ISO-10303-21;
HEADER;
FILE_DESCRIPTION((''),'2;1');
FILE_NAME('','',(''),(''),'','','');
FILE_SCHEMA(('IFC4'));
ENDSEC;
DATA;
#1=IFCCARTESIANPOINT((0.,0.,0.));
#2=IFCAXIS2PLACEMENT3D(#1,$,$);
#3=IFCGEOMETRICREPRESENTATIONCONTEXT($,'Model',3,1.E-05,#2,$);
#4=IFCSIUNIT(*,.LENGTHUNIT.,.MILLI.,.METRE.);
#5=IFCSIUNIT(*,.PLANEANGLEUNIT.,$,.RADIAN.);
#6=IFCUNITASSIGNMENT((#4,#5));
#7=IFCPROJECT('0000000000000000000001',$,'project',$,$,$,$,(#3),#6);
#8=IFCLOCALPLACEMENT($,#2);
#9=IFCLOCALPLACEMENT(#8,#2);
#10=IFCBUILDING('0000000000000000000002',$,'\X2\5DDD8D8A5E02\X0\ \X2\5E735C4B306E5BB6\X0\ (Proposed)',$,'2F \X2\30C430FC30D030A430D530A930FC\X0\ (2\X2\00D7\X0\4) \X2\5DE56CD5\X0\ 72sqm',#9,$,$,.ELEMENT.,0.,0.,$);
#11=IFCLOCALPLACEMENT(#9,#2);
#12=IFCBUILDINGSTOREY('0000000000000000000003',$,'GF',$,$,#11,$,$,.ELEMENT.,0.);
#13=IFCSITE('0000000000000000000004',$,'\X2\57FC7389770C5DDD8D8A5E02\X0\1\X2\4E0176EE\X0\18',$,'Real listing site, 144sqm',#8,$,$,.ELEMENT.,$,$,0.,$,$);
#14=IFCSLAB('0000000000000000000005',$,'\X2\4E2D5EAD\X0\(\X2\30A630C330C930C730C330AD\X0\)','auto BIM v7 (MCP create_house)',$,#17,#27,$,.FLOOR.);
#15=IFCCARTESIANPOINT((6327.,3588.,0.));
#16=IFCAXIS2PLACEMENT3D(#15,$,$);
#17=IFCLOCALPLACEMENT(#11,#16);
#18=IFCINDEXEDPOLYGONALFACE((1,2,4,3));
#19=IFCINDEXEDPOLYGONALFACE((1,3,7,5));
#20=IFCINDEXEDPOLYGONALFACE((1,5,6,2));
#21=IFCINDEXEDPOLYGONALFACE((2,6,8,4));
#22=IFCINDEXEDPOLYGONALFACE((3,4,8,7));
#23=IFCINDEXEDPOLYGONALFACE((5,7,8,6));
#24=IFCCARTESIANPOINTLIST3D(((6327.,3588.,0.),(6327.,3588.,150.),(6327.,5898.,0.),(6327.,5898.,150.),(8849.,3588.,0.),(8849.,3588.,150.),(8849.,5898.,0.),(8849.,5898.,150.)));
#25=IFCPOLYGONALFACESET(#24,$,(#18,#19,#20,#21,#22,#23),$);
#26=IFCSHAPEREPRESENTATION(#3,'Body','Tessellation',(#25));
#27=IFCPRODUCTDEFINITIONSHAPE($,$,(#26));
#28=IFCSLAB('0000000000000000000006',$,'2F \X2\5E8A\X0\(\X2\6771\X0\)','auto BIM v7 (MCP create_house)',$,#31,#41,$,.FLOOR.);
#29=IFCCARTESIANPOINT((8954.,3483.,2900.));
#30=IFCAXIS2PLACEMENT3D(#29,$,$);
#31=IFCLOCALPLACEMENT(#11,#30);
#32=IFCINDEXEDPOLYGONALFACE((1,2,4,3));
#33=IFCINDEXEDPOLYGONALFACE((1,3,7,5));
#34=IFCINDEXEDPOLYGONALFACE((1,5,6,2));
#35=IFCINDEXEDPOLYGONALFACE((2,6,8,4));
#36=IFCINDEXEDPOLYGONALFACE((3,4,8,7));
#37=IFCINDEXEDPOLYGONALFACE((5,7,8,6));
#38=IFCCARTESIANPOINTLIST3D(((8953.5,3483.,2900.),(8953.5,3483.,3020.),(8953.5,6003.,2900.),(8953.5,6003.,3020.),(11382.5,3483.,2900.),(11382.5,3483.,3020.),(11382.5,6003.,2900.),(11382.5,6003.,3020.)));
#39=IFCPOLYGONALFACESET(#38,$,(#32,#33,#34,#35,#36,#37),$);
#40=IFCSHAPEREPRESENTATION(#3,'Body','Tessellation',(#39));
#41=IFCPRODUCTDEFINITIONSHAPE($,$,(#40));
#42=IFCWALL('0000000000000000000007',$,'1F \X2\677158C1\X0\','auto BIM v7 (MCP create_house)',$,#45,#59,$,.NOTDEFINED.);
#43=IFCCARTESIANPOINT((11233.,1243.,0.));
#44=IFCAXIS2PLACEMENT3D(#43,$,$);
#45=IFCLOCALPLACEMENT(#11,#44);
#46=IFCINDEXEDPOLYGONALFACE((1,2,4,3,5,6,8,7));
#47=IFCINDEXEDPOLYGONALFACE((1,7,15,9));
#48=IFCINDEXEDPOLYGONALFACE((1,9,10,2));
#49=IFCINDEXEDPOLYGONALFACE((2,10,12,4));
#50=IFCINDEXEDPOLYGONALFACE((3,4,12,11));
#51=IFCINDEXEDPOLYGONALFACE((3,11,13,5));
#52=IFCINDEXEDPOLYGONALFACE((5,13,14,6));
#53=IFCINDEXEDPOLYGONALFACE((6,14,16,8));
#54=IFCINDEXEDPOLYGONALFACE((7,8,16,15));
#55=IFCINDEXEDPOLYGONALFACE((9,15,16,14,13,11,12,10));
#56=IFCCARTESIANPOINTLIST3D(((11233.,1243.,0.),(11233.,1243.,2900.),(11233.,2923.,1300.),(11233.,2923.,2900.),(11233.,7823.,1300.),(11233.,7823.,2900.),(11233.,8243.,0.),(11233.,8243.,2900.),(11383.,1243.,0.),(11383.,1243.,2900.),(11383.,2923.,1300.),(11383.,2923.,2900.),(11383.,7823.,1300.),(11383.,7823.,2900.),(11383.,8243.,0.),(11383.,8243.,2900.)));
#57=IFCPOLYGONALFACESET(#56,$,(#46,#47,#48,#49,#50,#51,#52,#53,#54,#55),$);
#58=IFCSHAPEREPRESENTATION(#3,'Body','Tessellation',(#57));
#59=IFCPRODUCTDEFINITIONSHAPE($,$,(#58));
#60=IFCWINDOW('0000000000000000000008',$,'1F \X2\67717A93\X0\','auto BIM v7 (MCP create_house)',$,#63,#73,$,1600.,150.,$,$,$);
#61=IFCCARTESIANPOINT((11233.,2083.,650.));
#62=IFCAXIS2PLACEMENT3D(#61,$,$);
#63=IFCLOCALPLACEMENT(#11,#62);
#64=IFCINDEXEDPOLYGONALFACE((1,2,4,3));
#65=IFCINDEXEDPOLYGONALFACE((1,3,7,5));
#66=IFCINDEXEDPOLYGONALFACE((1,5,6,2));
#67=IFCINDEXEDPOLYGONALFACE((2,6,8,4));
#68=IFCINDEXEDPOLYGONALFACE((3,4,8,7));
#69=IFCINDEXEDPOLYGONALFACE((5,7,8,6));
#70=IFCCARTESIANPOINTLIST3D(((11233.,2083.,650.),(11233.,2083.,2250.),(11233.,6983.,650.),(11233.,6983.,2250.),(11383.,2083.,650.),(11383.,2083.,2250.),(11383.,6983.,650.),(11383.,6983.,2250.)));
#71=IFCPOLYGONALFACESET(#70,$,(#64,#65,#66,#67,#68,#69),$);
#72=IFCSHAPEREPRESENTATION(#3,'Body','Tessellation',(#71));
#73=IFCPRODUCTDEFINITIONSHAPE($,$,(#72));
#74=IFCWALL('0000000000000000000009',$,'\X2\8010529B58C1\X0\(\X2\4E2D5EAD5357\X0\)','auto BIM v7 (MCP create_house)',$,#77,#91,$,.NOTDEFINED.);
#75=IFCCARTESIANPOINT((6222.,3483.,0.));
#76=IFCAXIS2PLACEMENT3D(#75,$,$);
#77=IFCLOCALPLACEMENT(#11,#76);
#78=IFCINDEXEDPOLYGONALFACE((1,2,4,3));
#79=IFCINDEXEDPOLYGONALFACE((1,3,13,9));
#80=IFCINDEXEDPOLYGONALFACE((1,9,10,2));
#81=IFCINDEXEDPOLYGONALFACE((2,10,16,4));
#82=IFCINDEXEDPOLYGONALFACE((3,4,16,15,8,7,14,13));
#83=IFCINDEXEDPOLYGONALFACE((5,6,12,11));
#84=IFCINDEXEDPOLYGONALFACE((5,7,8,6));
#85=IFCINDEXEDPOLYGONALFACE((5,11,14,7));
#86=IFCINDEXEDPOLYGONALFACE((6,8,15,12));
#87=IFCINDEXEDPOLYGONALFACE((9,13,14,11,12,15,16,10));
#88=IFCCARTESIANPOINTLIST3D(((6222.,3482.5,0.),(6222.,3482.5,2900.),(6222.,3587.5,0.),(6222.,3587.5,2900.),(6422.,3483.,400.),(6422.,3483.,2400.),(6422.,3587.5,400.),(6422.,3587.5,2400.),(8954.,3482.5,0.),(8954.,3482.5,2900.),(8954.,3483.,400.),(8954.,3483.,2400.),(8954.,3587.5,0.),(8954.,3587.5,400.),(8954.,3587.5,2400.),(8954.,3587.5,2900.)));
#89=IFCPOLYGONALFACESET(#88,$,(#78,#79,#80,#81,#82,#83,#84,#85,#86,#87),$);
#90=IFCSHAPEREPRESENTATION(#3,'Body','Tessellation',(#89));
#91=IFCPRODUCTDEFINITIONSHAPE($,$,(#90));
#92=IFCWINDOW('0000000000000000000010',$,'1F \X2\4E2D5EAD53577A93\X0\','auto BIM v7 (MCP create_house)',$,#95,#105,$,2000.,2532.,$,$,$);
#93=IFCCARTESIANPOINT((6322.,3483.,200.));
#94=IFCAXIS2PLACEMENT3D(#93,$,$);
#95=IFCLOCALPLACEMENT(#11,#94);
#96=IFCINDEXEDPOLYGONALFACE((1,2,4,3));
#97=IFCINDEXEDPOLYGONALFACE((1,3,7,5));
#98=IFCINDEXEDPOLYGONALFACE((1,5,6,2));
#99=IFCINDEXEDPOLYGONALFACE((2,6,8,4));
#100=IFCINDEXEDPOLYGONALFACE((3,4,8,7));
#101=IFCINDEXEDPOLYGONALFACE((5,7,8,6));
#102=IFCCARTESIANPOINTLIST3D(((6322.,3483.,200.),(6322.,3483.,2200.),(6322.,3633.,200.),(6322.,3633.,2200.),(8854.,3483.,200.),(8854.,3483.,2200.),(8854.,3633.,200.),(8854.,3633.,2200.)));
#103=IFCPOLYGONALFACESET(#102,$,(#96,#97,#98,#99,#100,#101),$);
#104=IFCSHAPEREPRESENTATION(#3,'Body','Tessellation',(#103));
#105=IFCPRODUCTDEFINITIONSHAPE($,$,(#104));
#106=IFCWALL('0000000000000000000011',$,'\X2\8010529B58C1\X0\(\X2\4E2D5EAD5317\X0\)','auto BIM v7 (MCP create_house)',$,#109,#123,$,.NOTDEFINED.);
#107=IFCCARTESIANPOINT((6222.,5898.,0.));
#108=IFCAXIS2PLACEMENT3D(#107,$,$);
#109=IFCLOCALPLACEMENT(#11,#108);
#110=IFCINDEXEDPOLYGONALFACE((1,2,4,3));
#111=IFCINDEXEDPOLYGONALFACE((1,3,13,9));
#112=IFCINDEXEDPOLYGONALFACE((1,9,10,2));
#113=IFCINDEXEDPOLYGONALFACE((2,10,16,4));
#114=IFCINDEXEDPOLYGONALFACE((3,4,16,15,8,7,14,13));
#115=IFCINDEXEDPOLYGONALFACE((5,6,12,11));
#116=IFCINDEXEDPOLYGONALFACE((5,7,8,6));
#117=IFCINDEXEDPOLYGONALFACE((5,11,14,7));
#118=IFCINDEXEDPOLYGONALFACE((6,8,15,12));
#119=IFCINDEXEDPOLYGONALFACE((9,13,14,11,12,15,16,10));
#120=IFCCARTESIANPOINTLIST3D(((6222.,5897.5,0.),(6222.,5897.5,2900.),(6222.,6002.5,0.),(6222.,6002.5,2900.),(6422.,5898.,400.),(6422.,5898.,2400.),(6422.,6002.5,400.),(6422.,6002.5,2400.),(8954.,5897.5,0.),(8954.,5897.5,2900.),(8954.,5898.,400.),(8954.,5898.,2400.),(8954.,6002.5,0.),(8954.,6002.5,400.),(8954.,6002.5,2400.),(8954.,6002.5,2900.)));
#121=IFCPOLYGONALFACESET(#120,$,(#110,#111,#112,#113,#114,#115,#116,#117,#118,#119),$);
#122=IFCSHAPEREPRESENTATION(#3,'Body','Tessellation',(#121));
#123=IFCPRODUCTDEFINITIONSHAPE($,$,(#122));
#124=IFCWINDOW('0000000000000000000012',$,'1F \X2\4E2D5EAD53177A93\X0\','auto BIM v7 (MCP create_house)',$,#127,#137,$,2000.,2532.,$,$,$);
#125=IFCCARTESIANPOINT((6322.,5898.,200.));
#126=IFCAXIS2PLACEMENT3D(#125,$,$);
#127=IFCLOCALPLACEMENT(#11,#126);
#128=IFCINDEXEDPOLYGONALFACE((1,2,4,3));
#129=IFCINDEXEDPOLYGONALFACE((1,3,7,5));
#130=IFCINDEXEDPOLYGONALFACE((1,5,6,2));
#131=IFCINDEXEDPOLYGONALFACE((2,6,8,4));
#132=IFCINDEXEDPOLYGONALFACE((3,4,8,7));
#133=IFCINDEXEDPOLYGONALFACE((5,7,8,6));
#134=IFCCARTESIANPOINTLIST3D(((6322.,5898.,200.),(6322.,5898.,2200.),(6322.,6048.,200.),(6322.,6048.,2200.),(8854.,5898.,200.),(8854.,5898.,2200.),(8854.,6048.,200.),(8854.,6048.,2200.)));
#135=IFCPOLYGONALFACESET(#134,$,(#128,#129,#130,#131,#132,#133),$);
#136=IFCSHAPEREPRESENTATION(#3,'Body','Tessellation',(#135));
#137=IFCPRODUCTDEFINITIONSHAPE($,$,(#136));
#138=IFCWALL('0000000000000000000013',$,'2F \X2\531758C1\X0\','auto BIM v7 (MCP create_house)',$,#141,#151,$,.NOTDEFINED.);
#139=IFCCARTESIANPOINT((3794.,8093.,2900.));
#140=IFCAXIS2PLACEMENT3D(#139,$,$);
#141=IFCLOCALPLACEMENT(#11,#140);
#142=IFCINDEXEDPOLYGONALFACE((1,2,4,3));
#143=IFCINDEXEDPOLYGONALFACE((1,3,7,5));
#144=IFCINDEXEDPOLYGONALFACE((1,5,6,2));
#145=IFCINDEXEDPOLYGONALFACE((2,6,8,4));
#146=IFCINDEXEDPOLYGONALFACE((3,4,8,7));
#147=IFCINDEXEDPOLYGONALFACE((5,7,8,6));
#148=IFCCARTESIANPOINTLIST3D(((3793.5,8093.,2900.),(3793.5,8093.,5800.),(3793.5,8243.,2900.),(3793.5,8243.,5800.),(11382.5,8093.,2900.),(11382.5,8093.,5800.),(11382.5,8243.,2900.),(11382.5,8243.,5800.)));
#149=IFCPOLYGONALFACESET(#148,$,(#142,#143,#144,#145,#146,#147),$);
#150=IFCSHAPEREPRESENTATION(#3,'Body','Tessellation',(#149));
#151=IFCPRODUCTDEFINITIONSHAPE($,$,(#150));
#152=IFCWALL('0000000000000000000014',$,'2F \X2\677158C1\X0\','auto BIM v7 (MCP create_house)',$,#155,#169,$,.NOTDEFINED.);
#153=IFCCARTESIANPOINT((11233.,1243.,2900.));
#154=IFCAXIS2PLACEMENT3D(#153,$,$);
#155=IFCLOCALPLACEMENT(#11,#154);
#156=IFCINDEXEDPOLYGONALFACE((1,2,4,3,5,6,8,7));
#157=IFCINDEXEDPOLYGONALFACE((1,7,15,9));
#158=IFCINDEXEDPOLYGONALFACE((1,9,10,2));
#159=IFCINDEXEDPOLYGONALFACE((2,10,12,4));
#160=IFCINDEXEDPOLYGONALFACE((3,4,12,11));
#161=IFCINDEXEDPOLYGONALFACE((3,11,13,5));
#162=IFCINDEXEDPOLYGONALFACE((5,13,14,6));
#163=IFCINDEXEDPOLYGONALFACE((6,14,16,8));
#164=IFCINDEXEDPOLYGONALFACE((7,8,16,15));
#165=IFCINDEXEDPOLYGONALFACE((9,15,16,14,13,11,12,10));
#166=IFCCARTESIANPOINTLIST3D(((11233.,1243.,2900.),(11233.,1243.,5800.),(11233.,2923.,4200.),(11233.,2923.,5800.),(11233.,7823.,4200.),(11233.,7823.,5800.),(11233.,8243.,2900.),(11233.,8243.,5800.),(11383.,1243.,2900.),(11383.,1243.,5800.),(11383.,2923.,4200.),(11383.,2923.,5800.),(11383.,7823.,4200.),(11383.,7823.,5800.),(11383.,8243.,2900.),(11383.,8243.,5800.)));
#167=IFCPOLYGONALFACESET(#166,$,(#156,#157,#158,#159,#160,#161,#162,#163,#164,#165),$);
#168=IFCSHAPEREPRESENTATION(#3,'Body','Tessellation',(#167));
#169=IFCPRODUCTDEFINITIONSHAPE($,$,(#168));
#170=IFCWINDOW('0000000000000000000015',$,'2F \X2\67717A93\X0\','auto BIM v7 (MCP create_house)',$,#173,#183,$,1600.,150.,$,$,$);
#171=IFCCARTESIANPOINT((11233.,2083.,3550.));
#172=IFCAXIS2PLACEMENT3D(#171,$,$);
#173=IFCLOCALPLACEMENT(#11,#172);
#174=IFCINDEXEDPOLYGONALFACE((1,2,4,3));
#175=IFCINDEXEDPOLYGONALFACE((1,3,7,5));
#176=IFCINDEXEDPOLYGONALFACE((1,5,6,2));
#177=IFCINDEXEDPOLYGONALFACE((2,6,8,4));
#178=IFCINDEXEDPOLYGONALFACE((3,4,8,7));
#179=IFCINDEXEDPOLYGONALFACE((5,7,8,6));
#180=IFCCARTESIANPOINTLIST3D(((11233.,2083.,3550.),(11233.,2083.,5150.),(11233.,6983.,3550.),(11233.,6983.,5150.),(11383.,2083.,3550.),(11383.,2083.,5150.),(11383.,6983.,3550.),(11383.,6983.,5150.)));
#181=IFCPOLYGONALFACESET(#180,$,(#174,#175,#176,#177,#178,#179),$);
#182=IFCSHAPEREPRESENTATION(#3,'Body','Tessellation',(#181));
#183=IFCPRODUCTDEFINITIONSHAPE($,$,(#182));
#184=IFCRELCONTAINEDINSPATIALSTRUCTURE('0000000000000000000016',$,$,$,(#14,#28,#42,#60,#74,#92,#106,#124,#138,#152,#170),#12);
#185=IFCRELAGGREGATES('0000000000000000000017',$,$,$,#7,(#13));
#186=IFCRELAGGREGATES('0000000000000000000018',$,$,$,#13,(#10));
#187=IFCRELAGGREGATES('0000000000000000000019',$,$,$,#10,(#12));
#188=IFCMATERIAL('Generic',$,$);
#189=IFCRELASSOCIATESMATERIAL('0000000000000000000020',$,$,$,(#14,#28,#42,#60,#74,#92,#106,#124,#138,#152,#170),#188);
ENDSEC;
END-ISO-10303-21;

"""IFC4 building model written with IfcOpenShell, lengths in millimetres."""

from ifc_helpers import new_model, si_unit, frame, frame_2d, origin, place, context, project, spatial, rectangle, extrude, material, element, fill, save


model = new_model("IFC4")

# Units and contexts
model_context = context("Model", 3, precision=1e-05, world=origin())
ifc_project = project(units=[si_unit("LENGTHUNIT", "METRE", prefix="MILLI"), si_unit("PLANEANGLEUNIT", "RADIAN")], contexts=[model_context])

# Site, building, storey
site_placement = place(None, origin())
site = spatial("IfcSite", under=ifc_project, at=site_placement, Name="埼玉県川越市1丁目18", ObjectType="Real listing site, 144sqm", CompositionType="ELEMENT", RefElevation=0.0)
building_placement = place(site_placement, origin())
building = spatial("IfcBuilding", under=site, at=building_placement, Name="川越市 平屋の家 (Proposed)", ObjectType="2F ツーバイフォー (2×4) 工法 72sqm", CompositionType="ELEMENT", ElevationOfRefHeight=0.0, ElevationOfTerrain=0.0)
storey_placement = place(building_placement, origin())
storey = spatial("IfcBuildingStorey", under=building, at=storey_placement, Name="GF", CompositionType="ELEMENT", Elevation=0.0)

# Slabs
ifc_material = material(Name="Generic")
slab_1_placement = place(storey_placement, frame((6327.0, 3588.0, 0.0)))
element("IfcSlab", 1, at=slab_1_placement, inside=storey, material=ifc_material, Name="中庭(ウッドデッキ)", Description="auto BIM v7 (MCP create_house)", PredefinedType="FLOOR", context=model_context, shape_type="SweptSolid", body=[
    extrude(rectangle(XDim=2522.0, YDim=2310.0, at=frame_2d((1261.0, 1155.0))), frame((6327.0, 3588.0, 0.0)), (0.0, 0.0, 1.0), 150.0),
])
slab_2_placement = place(storey_placement, frame((8954.0, 3483.0, 2900.0)))
element("IfcSlab", 2, at=slab_2_placement, inside=storey, material=ifc_material, Name="2F 床(東)", Description="auto BIM v7 (MCP create_house)", PredefinedType="FLOOR", context=model_context, shape_type="SweptSolid", body=[
    extrude(rectangle(XDim=2429.0, YDim=2520.0, at=frame_2d((1214.0, 1260.0))), frame((8954.0, 3483.0, 2900.0)), (0.0, 0.0, 1.0), 120.0),
])

# Walls, openings, windows
wall_1_placement = place(storey_placement, frame((11233.0, 1243.0, 0.0)))
wall_1 = element("IfcWall", 3, at=wall_1_placement, inside=storey, material=ifc_material, Name="1F 東壁", Description="auto BIM v7 (MCP create_house)", PredefinedType="NOTDEFINED", context=model_context, shape_type="SweptSolid", body=[
    extrude(rectangle(XDim=150.0, YDim=7000.0, at=frame_2d((75.0, 3500.0))), frame((11233.0, 1243.0, 0.0)), (0.0, 0.0, 1.0), 2900.0),
])
opening_1_placement = place(storey_placement, frame((11233.0, 2083.0, 650.0)))
opening_1 = element("IfcOpeningElement", 4, at=opening_1_placement, cuts=wall_1, PredefinedType="NOTDEFINED", context=model_context, shape_type="SweptSolid", body=[
    extrude(rectangle(XDim=150.0, YDim=4900.0, at=frame_2d((75.0, 2450.0))), frame((11233.0, 2083.0, 650.0)), (0.0, 0.0, 1.0), 1600.0),
])
window_1_placement = place(storey_placement, frame((11233.0, 2083.0, 650.0)))
window_1 = element("IfcWindow", 5, at=window_1_placement, inside=storey, material=ifc_material, Name="1F 東窓", Description="auto BIM v7 (MCP create_house)", OverallHeight=1600.0, OverallWidth=150.0, context=model_context, shape_type="SweptSolid", body=[
    extrude(rectangle(XDim=150.0, YDim=4900.0, at=frame_2d((75.0, 2450.0))), frame((11233.0, 2083.0, 650.0)), (0.0, 0.0, 1.0), 1600.0),
])
fill(opening_1, window_1)
wall_2_placement = place(storey_placement, frame((6222.0, 3483.0, 0.0)))
wall_2 = element("IfcWall", 6, at=wall_2_placement, inside=storey, material=ifc_material, Name="耐力壁(中庭南)", Description="auto BIM v7 (MCP create_house)", PredefinedType="NOTDEFINED", context=model_context, shape_type="SweptSolid", body=[
    extrude(rectangle(XDim=2732.0, YDim=105.0, at=frame_2d((1366.0, 52.0))), frame((6222.0, 3483.0, 0.0)), (0.0, 0.0, 1.0), 2900.0),
])
opening_2_placement = place(storey_placement, frame((6322.0, 3483.0, 200.0)))
opening_2 = element("IfcOpeningElement", 7, at=opening_2_placement, cuts=wall_2, PredefinedType="NOTDEFINED", context=model_context, shape_type="SweptSolid", body=[
    extrude(rectangle(XDim=2532.0, YDim=150.0, at=frame_2d((1266.0, 75.0))), frame((6322.0, 3483.0, 200.0)), (0.0, 0.0, 1.0), 2000.0),
])
window_2_placement = place(storey_placement, frame((6322.0, 3483.0, 200.0)))
window_2 = element("IfcWindow", 8, at=window_2_placement, inside=storey, material=ifc_material, Name="1F 中庭南窓", Description="auto BIM v7 (MCP create_house)", OverallHeight=2000.0, OverallWidth=2532.0, context=model_context, shape_type="SweptSolid", body=[
    extrude(rectangle(XDim=2532.0, YDim=150.0, at=frame_2d((1266.0, 75.0))), frame((6322.0, 3483.0, 200.0)), (0.0, 0.0, 1.0), 2000.0),
])
fill(opening_2, window_2)
wall_3_placement = place(storey_placement, frame((6222.0, 5898.0, 0.0)))
wall_3 = element("IfcWall", 9, at=wall_3_placement, inside=storey, material=ifc_material, Name="耐力壁(中庭北)", Description="auto BIM v7 (MCP create_house)", PredefinedType="NOTDEFINED", context=model_context, shape_type="SweptSolid", body=[
    extrude(rectangle(XDim=2732.0, YDim=105.0, at=frame_2d((1366.0, 52.0))), frame((6222.0, 5898.0, 0.0)), (0.0, 0.0, 1.0), 2900.0),
])
opening_3_placement = place(storey_placement, frame((6322.0, 5898.0, 200.0)))
opening_3 = element("IfcOpeningElement", 10, at=opening_3_placement, cuts=wall_3, PredefinedType="NOTDEFINED", context=model_context, shape_type="SweptSolid", body=[
    extrude(rectangle(XDim=2532.0, YDim=150.0, at=frame_2d((1266.0, 75.0))), frame((6322.0, 5898.0, 200.0)), (0.0, 0.0, 1.0), 2000.0),
])
window_3_placement = place(storey_placement, frame((6322.0, 5898.0, 200.0)))
window_3 = element("IfcWindow", 11, at=window_3_placement, inside=storey, material=ifc_material, Name="1F 中庭北窓", Description="auto BIM v7 (MCP create_house)", OverallHeight=2000.0, OverallWidth=2532.0, context=model_context, shape_type="SweptSolid", body=[
    extrude(rectangle(XDim=2532.0, YDim=150.0, at=frame_2d((1266.0, 75.0))), frame((6322.0, 5898.0, 200.0)), (0.0, 0.0, 1.0), 2000.0),
])
fill(opening_3, window_3)

# Wall
wall_4_placement = place(storey_placement, frame((3794.0, 8093.0, 2900.0)))
element("IfcWall", 12, at=wall_4_placement, inside=storey, material=ifc_material, Name="2F 北壁", Description="auto BIM v7 (MCP create_house)", PredefinedType="NOTDEFINED", context=model_context, shape_type="SweptSolid", body=[
    extrude(rectangle(XDim=7589.0, YDim=150.0, at=frame_2d((3794.0, 75.0))), frame((3794.0, 8093.0, 2900.0)), (0.0, 0.0, 1.0), 2900.0),
])

# Wall, opening, window
wall_5_placement = place(storey_placement, frame((11233.0, 1243.0, 2900.0)))
wall_5 = element("IfcWall", 13, at=wall_5_placement, inside=storey, material=ifc_material, Name="2F 東壁", Description="auto BIM v7 (MCP create_house)", PredefinedType="NOTDEFINED", context=model_context, shape_type="SweptSolid", body=[
    extrude(rectangle(XDim=150.0, YDim=7000.0, at=frame_2d((75.0, 3500.0))), frame((11233.0, 1243.0, 2900.0)), (0.0, 0.0, 1.0), 2900.0),
])
opening_4_placement = place(storey_placement, frame((11233.0, 2083.0, 3550.0)))
opening_4 = element("IfcOpeningElement", 14, at=opening_4_placement, cuts=wall_5, PredefinedType="NOTDEFINED", context=model_context, shape_type="SweptSolid", body=[
    extrude(rectangle(XDim=150.0, YDim=4900.0, at=frame_2d((75.0, 2450.0))), frame((11233.0, 2083.0, 3550.0)), (0.0, 0.0, 1.0), 1600.0),
])
window_4_placement = place(storey_placement, frame((11233.0, 2083.0, 3550.0)))
window_4 = element("IfcWindow", 15, at=window_4_placement, inside=storey, material=ifc_material, Name="2F 東窓", Description="auto BIM v7 (MCP create_house)", OverallHeight=1600.0, OverallWidth=150.0, context=model_context, shape_type="SweptSolid", body=[
    extrude(rectangle(XDim=150.0, YDim=4900.0, at=frame_2d((75.0, 2450.0))), frame((11233.0, 2083.0, 3550.0)), (0.0, 0.0, 1.0), 1600.0),
])
fill(opening_4, window_4)

save(model, "model.ifc")
